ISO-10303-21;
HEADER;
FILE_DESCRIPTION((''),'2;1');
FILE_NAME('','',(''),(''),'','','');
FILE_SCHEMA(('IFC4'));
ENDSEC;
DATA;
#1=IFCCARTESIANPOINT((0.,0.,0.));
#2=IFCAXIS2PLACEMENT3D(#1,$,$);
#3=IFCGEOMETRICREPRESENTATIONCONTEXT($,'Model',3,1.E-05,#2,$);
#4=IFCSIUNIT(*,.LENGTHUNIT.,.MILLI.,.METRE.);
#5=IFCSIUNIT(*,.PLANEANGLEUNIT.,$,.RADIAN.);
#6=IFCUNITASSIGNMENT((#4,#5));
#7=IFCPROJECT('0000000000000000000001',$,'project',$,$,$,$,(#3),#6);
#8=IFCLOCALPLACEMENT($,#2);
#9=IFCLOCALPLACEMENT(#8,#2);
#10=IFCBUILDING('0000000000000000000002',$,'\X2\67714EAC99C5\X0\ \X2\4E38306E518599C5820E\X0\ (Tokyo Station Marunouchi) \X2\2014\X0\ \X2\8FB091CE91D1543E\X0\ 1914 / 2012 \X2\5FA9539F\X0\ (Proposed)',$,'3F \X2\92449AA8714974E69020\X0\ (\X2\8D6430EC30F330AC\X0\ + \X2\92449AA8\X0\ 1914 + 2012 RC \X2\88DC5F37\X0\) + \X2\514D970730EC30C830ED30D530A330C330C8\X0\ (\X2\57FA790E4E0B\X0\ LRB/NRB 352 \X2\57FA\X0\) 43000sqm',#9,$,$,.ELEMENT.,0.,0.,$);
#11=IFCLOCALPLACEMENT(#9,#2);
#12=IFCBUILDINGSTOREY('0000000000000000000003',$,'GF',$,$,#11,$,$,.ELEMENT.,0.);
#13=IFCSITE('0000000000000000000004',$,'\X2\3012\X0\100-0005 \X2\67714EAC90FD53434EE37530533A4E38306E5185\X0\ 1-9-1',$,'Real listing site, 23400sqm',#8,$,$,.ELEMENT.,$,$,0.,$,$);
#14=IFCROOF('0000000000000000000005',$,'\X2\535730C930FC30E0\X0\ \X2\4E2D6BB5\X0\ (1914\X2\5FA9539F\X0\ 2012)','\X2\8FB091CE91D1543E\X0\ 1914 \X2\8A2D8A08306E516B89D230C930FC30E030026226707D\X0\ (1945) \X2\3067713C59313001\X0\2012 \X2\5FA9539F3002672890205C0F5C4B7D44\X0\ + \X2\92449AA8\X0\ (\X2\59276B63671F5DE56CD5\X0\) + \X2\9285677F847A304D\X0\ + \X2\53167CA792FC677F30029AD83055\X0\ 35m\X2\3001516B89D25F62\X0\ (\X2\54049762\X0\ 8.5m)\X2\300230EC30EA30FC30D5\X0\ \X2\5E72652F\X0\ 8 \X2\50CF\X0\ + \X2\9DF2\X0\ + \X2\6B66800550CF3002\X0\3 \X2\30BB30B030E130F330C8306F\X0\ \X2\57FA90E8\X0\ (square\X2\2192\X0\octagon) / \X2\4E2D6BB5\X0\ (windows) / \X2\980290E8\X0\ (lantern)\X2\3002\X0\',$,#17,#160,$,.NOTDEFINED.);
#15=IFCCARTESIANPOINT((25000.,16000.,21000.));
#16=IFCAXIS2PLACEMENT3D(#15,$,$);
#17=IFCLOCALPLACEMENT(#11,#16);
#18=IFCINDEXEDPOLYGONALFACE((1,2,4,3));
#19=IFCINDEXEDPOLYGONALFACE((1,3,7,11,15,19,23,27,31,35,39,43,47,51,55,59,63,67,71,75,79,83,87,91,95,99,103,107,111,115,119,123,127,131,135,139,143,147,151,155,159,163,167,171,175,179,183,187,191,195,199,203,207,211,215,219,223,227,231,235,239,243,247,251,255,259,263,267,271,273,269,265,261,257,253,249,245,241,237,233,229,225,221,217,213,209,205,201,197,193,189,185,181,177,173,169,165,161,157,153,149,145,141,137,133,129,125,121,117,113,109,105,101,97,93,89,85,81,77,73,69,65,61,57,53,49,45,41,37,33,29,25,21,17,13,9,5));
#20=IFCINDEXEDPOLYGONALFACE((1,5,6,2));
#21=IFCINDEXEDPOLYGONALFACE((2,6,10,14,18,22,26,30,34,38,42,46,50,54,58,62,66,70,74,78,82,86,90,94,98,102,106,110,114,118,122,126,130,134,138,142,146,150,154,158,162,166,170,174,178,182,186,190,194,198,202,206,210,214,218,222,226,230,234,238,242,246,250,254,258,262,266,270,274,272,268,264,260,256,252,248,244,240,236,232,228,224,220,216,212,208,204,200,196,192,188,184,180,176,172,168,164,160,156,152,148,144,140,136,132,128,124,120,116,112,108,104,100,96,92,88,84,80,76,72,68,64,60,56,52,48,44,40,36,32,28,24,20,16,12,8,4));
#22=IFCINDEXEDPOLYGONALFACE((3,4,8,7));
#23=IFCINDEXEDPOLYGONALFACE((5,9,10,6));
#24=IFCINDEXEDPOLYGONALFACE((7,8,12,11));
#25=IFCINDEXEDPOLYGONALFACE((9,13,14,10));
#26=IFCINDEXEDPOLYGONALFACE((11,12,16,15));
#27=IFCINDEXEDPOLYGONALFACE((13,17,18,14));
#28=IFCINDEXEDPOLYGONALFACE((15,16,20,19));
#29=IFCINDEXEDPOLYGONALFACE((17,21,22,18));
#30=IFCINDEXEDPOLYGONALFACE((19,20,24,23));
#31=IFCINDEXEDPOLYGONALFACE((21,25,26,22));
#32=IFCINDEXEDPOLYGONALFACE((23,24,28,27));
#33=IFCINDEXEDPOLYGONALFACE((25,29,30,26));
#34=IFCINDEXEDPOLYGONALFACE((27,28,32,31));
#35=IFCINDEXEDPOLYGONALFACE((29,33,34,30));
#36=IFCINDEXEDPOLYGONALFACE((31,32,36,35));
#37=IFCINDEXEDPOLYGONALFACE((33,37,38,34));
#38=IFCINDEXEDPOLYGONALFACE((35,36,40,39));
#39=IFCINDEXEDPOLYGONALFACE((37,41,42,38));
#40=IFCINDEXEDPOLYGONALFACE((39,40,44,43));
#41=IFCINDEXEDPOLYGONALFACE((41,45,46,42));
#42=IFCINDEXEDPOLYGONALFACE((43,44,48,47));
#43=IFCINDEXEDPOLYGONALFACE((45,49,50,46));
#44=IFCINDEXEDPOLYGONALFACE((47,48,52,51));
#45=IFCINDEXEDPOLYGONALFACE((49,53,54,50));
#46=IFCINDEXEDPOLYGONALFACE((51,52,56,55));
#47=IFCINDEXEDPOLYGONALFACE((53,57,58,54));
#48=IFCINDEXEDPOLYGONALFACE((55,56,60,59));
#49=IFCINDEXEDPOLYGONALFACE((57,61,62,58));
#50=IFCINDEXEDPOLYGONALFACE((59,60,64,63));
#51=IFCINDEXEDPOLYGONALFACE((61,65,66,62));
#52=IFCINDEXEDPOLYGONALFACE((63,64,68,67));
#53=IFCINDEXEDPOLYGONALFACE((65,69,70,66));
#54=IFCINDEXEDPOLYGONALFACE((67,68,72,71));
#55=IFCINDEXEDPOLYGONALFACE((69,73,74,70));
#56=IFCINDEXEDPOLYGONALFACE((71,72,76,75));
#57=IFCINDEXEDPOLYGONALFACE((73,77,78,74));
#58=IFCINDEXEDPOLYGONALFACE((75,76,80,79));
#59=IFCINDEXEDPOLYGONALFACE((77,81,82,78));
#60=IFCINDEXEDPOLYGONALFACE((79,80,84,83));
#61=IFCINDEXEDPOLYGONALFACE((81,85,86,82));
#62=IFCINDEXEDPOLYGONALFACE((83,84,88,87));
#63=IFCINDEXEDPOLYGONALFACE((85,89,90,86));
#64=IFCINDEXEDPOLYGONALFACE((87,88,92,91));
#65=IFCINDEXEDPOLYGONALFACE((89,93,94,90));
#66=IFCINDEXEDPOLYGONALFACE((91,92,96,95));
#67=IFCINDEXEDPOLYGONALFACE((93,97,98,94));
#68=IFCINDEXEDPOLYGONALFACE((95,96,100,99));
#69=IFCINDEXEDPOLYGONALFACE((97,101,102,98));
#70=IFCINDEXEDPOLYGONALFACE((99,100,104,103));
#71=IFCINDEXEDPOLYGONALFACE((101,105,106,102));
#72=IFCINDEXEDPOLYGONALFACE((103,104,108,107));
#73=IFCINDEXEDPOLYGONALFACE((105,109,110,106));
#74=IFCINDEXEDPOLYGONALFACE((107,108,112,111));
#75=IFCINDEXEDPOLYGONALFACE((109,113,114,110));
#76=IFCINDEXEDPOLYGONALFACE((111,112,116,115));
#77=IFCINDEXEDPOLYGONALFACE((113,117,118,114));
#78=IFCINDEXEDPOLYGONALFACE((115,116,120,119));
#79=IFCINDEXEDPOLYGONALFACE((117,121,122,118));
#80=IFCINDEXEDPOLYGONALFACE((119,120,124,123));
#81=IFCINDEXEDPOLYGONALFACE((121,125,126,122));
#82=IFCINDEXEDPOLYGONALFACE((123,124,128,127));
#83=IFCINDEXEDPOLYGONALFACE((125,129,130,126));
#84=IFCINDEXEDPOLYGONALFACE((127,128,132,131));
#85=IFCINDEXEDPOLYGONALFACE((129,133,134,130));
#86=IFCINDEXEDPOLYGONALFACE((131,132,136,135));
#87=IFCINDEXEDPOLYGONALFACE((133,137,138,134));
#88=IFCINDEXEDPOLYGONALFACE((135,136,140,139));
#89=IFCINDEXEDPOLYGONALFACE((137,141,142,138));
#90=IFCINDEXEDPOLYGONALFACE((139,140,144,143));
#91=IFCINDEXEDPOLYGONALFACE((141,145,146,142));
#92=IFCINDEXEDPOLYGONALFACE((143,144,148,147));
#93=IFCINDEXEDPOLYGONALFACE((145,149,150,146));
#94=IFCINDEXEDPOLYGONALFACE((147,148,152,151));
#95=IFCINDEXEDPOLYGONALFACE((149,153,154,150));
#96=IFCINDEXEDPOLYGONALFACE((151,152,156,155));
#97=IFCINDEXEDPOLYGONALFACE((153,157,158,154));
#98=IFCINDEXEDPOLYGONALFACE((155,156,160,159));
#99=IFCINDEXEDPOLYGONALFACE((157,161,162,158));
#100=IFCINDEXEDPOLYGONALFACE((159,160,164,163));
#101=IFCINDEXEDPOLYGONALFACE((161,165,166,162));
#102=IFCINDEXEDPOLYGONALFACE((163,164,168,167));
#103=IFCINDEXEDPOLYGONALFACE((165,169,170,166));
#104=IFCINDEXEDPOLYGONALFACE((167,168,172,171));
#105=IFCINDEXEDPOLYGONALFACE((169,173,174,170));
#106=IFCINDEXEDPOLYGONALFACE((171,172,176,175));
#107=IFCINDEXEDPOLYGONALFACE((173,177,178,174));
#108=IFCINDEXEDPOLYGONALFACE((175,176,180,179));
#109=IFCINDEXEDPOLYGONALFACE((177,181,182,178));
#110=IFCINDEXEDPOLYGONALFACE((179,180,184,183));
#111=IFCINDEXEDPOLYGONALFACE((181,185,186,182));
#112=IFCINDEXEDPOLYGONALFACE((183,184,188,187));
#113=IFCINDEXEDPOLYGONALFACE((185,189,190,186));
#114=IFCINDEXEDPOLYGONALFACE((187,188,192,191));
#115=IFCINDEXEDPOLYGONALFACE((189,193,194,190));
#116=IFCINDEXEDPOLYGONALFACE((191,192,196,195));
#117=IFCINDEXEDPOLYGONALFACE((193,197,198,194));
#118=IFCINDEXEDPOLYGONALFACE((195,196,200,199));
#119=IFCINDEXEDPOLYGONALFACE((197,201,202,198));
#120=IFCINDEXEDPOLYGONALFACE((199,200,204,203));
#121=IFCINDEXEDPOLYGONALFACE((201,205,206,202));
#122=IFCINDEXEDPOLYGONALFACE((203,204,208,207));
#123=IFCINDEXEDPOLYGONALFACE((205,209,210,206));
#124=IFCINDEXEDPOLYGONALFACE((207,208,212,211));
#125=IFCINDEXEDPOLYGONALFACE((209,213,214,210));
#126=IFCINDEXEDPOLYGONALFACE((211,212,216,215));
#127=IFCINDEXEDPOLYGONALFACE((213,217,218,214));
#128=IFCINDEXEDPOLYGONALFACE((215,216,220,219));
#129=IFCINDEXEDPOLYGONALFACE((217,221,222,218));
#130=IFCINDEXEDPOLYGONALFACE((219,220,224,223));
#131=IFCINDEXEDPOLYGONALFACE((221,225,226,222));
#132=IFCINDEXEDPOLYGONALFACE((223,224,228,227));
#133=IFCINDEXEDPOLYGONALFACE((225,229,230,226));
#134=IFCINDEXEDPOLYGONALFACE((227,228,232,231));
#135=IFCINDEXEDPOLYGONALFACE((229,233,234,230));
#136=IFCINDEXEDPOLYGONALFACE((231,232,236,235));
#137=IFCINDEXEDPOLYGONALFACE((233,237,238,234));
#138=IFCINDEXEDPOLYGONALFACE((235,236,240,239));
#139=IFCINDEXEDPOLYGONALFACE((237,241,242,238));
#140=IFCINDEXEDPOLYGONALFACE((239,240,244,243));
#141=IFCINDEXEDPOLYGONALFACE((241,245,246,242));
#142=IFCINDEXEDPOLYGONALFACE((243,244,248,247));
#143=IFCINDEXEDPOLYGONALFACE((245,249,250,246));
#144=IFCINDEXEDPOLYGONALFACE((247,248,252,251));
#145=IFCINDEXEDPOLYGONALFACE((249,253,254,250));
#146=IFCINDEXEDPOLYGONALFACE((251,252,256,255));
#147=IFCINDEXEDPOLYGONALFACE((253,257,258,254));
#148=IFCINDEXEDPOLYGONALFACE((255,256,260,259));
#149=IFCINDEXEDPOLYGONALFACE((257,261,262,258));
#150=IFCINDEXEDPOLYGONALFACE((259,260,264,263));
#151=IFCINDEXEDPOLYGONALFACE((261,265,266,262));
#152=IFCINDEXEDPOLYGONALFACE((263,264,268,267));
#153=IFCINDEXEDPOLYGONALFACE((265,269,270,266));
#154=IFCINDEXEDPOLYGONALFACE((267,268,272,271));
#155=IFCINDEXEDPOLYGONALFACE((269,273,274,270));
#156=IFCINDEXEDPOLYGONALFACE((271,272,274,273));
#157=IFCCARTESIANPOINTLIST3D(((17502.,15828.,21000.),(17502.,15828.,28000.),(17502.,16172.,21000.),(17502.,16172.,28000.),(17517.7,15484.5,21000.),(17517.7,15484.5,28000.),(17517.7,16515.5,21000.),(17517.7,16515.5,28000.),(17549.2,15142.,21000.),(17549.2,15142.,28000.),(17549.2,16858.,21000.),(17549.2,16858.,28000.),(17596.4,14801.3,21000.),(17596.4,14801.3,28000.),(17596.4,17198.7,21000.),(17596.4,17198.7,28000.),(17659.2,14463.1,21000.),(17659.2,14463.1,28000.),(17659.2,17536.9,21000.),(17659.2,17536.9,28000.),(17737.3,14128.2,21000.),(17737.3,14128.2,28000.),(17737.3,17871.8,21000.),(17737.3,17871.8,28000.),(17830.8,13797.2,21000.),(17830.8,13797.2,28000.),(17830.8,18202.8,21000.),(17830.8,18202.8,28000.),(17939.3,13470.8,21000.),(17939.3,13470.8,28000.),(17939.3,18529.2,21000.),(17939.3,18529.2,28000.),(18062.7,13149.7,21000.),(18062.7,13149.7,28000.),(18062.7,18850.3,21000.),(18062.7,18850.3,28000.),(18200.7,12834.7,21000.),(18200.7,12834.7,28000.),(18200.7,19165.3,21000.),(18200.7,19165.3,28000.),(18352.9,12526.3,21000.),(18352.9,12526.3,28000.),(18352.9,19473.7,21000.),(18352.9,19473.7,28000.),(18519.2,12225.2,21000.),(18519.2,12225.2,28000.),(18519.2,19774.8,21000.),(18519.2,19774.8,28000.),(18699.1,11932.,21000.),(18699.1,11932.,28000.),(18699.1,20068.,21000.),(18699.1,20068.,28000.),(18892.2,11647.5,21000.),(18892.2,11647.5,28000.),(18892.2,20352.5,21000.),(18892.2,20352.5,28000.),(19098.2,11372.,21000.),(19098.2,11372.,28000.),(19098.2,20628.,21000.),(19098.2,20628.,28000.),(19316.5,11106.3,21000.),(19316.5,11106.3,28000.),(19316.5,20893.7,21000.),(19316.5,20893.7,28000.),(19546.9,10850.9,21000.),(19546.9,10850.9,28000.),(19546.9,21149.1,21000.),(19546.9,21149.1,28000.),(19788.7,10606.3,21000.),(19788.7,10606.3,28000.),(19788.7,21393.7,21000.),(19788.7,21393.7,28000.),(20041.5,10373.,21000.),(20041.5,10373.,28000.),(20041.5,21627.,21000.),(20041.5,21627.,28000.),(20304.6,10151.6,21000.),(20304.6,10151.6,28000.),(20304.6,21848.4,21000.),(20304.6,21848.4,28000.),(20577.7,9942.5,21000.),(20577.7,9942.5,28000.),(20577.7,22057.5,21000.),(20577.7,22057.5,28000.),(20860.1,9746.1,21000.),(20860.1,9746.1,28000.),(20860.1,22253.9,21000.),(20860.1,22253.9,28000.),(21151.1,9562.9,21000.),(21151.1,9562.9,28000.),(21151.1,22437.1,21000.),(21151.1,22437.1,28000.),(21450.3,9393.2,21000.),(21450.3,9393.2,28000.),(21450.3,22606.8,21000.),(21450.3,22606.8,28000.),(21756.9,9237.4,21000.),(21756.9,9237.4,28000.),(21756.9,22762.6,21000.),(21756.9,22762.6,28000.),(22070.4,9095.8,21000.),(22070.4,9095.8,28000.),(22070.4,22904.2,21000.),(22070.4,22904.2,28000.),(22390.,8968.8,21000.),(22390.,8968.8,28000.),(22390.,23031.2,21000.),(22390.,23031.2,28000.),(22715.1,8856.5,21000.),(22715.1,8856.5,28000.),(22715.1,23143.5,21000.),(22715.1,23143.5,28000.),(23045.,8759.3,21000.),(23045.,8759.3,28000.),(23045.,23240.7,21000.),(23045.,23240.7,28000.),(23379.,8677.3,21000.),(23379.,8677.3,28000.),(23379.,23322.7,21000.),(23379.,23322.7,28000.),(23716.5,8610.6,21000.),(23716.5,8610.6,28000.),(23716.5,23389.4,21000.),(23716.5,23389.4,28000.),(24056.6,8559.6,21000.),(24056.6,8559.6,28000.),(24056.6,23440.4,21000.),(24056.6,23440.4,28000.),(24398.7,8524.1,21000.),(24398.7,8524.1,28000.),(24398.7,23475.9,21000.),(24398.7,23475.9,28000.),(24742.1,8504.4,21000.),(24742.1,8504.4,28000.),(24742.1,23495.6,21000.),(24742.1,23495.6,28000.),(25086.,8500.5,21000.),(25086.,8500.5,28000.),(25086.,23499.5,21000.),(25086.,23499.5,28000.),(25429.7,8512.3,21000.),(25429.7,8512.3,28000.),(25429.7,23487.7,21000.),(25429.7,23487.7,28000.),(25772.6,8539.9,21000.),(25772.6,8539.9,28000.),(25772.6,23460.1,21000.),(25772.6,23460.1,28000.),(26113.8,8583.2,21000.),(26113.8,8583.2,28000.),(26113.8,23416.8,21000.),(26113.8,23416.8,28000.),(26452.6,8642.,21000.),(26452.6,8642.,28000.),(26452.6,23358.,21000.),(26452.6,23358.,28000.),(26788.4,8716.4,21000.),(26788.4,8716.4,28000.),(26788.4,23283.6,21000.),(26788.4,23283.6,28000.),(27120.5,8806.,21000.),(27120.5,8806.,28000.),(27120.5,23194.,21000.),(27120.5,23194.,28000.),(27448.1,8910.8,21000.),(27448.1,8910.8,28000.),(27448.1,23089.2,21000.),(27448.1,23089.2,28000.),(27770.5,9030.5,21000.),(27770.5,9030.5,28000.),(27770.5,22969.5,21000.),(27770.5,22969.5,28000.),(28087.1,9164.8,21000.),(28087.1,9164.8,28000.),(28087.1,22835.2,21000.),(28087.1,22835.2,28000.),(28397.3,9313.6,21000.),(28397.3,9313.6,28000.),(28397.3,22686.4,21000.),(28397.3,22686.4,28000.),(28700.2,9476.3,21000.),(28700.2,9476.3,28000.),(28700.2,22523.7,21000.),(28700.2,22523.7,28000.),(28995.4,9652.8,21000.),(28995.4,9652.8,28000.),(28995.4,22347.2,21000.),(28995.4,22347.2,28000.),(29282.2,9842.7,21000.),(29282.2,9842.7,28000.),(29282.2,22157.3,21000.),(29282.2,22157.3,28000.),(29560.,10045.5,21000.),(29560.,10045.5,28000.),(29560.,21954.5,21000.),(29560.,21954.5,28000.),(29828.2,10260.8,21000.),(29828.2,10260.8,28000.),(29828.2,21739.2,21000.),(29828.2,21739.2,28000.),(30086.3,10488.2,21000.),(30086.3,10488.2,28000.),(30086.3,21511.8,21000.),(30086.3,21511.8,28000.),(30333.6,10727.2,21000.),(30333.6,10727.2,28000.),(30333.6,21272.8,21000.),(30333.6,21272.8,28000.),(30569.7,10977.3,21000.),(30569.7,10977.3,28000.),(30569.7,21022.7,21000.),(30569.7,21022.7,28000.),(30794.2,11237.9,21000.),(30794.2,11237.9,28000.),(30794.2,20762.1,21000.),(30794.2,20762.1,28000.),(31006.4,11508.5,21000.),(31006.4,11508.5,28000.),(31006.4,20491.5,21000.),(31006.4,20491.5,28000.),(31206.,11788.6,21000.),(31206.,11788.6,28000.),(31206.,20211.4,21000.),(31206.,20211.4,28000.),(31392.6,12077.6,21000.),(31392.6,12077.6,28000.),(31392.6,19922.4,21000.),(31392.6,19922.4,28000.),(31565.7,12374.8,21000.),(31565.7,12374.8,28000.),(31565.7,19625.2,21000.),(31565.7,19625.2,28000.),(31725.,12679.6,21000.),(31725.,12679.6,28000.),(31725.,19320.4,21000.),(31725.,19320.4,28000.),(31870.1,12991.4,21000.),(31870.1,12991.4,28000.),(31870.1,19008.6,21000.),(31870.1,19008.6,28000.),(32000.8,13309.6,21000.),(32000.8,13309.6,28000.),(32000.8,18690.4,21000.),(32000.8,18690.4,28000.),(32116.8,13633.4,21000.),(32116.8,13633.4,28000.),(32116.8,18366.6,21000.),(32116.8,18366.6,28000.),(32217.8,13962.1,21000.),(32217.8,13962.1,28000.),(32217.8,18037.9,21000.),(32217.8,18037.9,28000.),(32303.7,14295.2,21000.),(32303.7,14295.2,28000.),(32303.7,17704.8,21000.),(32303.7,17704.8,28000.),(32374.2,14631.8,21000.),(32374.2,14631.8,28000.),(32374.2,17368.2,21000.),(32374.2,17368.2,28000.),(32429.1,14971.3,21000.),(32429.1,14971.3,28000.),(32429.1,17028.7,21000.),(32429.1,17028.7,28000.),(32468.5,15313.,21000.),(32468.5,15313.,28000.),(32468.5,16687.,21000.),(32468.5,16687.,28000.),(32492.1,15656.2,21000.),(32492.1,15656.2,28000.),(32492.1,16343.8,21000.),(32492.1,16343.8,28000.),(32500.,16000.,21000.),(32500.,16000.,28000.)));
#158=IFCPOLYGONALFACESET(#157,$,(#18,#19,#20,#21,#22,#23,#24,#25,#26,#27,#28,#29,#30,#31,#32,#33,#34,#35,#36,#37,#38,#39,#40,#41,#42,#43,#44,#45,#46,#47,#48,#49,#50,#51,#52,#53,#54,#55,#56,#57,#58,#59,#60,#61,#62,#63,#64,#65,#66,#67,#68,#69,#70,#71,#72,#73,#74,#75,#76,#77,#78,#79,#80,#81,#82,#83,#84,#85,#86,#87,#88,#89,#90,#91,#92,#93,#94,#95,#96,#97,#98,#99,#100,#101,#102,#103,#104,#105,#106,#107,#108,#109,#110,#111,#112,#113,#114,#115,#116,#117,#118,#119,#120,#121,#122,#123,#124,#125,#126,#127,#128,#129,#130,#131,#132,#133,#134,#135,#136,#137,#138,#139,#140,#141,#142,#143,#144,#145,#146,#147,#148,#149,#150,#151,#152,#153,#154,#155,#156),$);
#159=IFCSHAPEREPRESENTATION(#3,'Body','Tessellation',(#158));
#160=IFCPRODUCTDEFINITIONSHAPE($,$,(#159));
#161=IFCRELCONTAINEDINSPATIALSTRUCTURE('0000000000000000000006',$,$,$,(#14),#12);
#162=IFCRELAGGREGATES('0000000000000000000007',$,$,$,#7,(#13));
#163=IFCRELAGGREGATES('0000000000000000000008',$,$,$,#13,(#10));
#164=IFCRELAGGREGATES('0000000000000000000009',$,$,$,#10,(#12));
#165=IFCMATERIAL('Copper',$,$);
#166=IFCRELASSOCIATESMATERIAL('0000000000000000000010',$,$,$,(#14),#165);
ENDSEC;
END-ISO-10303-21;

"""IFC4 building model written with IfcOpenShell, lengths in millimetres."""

from ifc_helpers import new_model, si_unit, frame, origin, origin_2d, place, context, project, spatial, circle, extrude, material, element, save


model = new_model("IFC4")

# Units and contexts
model_context = context("Model", 3, precision=1e-05, world=origin())
ifc_project = project(units=[si_unit("LENGTHUNIT", "METRE", prefix="MILLI"), si_unit("PLANEANGLEUNIT", "RADIAN")], contexts=[model_context])

# Site, building, storey
site_placement = place(None, origin())
site = spatial("IfcSite", under=ifc_project, at=site_placement, Name="〒100-0005 東京都千代田区丸の内 1-9-1", ObjectType="Real listing site, 23400sqm", CompositionType="ELEMENT", RefElevation=0.0)
building_placement = place(site_placement, origin())
building = spatial("IfcBuilding", under=site, at=building_placement, Name="東京駅 丸の内駅舎 (Tokyo Station Marunouchi) — 辰野金吾 1914 / 2012 復原 (Proposed)", ObjectType="3F 鉄骨煉瓦造 (赤レンガ + 鉄骨 1914 + 2012 RC 補強) + 免震レトロフィット (基礎下 LRB/NRB 352 基) 43000sqm", CompositionType="ELEMENT", ElevationOfRefHeight=0.0, ElevationOfTerrain=0.0)
storey_placement = place(building_placement, origin())
storey = spatial("IfcBuildingStorey", under=building, at=storey_placement, Name="GF", CompositionType="ELEMENT", Elevation=0.0)

# Roof
ifc_material_1 = material(Name="Copper")
roof_1_placement = place(storey_placement, frame((25000.0, 16000.0, 21000.0)))
element("IfcRoof", 1, at=roof_1_placement, inside=storey, material=ifc_material_1, Name="南ドーム 中段 (1914復原 2012)", Description="辰野金吾 1914 設計の八角ドーム。戦災 (1945) で焼失、2012 復原。木造小屋組 + 鉄骨 (大正期工法) + 銅板葺き + 化粧鋼板。高さ 35m、八角形 (各面 8.5m)。レリーフ 干支 8 像 + 鷲 + 武者像。3 セグメントは 基部 (square→octagon) / 中段 (windows) / 頂部 (lantern)。", PredefinedType="NOTDEFINED", context=model_context, shape_type="SweptSolid", body=[
    extrude(circle(Radius=7500.0, at=origin_2d()), frame((25000.0, 16000.0, 21000.0)), (0.0, 0.0, 1.0), 7000.0),
])

save(model, "model.ifc")
